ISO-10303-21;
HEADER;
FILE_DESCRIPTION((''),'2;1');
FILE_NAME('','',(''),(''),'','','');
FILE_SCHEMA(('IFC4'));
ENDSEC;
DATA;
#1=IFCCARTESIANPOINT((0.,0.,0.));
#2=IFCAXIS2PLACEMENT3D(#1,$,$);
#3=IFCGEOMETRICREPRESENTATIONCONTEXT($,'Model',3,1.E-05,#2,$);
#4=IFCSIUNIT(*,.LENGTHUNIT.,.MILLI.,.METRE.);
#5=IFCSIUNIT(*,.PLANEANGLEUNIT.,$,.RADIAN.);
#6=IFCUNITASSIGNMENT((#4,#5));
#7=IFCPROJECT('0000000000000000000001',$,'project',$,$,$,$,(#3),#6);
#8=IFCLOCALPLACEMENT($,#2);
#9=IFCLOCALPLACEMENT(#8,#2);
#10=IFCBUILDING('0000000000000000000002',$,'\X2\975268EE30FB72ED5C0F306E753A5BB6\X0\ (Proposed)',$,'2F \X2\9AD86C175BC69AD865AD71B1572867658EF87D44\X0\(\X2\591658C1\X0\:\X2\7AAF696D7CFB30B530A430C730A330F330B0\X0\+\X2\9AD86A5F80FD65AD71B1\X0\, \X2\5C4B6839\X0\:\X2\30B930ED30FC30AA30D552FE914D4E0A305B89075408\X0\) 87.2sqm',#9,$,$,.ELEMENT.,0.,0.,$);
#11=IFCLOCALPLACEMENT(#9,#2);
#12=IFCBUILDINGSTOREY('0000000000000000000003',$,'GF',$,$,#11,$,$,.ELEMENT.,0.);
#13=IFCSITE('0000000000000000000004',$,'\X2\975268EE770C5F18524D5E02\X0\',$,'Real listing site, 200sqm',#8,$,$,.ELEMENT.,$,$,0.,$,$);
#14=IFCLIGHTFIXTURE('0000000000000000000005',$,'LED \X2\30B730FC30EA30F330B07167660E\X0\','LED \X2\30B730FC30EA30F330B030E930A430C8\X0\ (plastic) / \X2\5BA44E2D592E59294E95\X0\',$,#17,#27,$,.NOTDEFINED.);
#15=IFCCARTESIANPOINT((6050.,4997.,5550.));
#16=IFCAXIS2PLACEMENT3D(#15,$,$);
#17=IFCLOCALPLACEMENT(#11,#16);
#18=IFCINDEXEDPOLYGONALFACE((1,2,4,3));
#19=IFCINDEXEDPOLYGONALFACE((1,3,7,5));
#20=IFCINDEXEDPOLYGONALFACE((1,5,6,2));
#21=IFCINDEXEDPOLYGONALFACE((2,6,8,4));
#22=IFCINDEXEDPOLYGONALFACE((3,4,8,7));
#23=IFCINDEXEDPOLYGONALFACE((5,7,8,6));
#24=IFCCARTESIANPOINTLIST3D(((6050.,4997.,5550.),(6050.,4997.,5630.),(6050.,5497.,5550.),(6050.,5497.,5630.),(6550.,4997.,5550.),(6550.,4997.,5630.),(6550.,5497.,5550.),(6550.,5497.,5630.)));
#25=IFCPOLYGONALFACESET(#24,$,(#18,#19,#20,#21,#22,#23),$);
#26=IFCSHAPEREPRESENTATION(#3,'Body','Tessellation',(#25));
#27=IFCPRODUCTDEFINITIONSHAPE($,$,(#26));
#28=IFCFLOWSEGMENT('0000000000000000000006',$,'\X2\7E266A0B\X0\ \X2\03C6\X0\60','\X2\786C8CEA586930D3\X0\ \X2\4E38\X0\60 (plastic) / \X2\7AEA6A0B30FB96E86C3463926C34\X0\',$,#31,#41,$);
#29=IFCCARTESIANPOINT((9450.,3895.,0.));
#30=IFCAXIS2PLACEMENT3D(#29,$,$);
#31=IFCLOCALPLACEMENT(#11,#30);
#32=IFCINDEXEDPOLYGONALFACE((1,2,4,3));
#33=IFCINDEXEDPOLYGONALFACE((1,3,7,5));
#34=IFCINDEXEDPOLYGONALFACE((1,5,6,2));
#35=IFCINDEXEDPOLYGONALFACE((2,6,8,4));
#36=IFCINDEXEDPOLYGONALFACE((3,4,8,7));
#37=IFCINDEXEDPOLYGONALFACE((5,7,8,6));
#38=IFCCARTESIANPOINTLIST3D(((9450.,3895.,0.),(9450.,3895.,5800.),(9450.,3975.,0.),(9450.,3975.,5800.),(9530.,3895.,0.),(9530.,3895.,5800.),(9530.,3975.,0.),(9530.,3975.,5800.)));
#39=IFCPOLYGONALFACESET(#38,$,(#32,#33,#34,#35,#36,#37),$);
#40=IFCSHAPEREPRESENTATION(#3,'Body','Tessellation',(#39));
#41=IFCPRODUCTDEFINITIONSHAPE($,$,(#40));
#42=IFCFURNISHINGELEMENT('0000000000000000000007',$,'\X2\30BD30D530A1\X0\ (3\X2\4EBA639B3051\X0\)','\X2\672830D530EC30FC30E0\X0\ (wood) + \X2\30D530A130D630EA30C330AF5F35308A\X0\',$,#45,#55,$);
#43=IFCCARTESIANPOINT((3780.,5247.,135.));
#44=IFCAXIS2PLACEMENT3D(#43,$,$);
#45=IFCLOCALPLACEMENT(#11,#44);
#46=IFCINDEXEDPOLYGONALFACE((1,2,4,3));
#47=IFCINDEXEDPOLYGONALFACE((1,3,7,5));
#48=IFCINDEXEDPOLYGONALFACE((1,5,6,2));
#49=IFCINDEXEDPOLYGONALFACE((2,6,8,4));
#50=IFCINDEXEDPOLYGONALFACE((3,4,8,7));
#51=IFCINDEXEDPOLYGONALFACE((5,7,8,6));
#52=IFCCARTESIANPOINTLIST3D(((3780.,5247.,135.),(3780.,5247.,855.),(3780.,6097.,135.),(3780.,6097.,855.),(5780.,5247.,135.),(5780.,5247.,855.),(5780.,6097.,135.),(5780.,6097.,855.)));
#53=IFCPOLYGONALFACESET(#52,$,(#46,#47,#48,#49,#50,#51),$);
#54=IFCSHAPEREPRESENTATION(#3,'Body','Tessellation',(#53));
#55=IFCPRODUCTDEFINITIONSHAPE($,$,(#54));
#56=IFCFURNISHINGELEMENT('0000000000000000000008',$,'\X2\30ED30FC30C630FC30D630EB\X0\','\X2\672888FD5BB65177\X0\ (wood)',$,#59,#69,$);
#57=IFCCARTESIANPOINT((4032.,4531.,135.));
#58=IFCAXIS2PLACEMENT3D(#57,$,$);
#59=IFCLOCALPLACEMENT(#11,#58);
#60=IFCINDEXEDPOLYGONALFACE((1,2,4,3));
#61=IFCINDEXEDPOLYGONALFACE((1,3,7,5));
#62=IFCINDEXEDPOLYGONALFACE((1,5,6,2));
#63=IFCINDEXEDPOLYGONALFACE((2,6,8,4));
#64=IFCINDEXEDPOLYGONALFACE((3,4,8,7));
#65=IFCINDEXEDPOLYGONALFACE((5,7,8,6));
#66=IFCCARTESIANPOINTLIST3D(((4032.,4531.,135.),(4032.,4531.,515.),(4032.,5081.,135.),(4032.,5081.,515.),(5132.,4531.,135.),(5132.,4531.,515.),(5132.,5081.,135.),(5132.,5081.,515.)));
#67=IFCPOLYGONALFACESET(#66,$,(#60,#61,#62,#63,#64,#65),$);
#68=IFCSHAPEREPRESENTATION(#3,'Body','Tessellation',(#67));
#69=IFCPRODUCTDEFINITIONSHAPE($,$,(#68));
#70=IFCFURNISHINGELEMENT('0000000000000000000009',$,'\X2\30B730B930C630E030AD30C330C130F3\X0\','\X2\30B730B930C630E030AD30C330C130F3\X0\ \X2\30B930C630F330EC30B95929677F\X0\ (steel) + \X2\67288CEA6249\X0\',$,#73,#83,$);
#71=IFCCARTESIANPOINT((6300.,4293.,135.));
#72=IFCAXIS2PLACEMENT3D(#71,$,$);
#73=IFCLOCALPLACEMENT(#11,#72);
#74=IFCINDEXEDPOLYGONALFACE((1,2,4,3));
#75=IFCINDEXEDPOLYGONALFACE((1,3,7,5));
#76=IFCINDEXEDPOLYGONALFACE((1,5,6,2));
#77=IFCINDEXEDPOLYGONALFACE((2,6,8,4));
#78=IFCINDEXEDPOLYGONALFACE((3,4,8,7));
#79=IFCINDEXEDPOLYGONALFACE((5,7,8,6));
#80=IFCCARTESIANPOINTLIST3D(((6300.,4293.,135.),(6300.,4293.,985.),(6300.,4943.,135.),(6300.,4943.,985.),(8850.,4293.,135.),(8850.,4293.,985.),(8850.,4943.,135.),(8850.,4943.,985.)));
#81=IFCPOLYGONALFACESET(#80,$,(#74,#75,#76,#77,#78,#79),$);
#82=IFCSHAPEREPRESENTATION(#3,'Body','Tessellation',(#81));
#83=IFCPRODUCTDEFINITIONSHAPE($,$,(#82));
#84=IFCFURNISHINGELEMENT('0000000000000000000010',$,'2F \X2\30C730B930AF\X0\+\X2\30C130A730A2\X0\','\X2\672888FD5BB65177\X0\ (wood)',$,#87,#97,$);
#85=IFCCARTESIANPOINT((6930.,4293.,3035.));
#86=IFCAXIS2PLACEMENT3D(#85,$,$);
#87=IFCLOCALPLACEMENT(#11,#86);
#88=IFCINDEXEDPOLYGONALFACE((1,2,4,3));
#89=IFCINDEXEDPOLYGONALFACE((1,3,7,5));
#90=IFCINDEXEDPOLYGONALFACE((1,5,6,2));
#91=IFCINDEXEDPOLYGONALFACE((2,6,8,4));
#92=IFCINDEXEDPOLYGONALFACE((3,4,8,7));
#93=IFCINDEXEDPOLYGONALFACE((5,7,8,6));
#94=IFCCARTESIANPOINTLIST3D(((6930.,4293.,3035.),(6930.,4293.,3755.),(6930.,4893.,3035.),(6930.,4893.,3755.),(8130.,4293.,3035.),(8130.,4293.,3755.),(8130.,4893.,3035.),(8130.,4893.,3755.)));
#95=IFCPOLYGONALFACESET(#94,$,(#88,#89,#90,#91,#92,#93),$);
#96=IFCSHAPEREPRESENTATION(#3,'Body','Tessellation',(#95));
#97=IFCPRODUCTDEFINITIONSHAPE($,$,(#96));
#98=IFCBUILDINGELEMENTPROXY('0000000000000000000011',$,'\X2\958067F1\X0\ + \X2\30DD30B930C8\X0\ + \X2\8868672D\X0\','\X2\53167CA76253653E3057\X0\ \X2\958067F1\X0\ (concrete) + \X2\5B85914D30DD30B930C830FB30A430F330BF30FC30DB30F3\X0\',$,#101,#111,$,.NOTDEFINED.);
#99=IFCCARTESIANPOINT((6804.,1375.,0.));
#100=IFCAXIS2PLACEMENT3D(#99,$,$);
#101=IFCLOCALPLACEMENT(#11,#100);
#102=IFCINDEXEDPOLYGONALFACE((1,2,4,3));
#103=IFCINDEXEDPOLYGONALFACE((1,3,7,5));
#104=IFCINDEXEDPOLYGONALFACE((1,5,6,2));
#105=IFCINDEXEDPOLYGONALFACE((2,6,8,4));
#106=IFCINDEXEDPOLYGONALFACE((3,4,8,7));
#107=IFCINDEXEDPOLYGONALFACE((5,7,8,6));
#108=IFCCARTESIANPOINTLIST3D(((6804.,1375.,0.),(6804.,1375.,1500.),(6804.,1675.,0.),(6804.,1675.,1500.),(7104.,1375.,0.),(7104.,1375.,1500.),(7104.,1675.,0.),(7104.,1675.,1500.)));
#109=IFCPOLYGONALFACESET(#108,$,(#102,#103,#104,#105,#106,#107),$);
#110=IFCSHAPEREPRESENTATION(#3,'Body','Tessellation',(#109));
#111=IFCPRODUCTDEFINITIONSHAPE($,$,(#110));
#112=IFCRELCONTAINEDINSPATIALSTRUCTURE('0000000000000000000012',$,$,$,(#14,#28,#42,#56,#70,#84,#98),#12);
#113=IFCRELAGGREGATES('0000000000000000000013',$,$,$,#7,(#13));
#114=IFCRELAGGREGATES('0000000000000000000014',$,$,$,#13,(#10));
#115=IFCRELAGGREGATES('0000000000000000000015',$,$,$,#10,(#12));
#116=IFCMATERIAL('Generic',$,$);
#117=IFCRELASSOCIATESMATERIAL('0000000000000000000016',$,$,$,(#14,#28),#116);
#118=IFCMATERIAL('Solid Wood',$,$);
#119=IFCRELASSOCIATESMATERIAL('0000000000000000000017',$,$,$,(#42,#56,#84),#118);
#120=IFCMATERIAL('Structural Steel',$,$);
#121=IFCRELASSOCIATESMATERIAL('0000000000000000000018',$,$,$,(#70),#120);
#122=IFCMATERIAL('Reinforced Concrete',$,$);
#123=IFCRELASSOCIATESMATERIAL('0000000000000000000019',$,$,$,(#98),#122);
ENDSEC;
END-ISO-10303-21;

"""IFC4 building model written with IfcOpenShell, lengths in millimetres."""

from ifc_helpers import new_model, si_unit, frame, frame_2d, origin, place, context, project, spatial, rectangle, extrude, material, element, save


model = new_model("IFC4")

# Units and contexts
model_context = context("Model", 3, precision=1e-05, world=origin())
ifc_project = project(units=[si_unit("LENGTHUNIT", "METRE", prefix="MILLI"), si_unit("PLANEANGLEUNIT", "RADIAN")], contexts=[model_context])

# Site, building, storey
site_placement = place(None, origin())
site = spatial("IfcSite", under=ifc_project, at=site_placement, Name="青森県弘前市", ObjectType="Real listing site, 200sqm", CompositionType="ELEMENT", RefElevation=0.0)
building_placement = place(site_placement, origin())
building = spatial("IfcBuilding", under=site, at=building_placement, Name="青森・狭小の町家 (Proposed)", ObjectType="2F 高気密高断熱在来軸組(外壁:窯業系サイディング+高機能断熱, 屋根:スローオフ勾配上せ複合) 87.2sqm", CompositionType="ELEMENT", ElevationOfRefHeight=0.0, ElevationOfTerrain=0.0)
storey_placement = place(building_placement, origin())
storey = spatial("IfcBuildingStorey", under=building, at=storey_placement, Name="GF", CompositionType="ELEMENT", Elevation=0.0)

# Shared definitions
ifc_material_1 = material(Name="Solid Wood")

# Shared definitions
ifc_material_2 = material(Name="Reinforced Concrete")

# Shared definitions
ifc_material_3 = material(Name="Structural Steel")

# Shared definitions
ifc_material_4 = material(Name="Generic")

# Light fixture
light_fixture_1_placement = place(storey_placement, frame((6050.0, 4997.0, 5550.0)))
element("IfcLightFixture", 1, at=light_fixture_1_placement, inside=storey, material=ifc_material_4, Name="LED シーリング照明", Description="LED シーリングライト (plastic) / 室中央天井", PredefinedType="NOTDEFINED", context=model_context, shape_type="SweptSolid", body=[
    extrude(rectangle(XDim=500.0, YDim=500.0, at=frame_2d((250.0, 250.0))), frame((6050.0, 4997.0, 5550.0)), (0.0, 0.0, 1.0), 80.0),
])

# Flow segment
flow_segment_placement = place(storey_placement, frame((9450.0, 3895.0, 0.0)))
element("IfcFlowSegment", 2, at=flow_segment_placement, inside=storey, material=ifc_material_4, Name="縦樋 φ60", Description="硬質塩ビ 丸60 (plastic) / 竪樋・雨水排水", context=model_context, shape_type="SweptSolid", body=[
    extrude(rectangle(XDim=80.0, YDim=80.0, at=frame_2d((40.0, 40.0))), frame((9450.0, 3895.0, 0.0)), (0.0, 0.0, 1.0), 5800.0),
])

# Furnishing elements
furnishing_1_placement = place(storey_placement, frame((3780.0, 5247.0, 135.0)))
element("IfcFurnishingElement", 3, at=furnishing_1_placement, inside=storey, material=ifc_material_1, Name="ソファ (3人掛け)", Description="木フレーム (wood) + ファブリック張り", context=model_context, shape_type="SweptSolid", body=[
    extrude(rectangle(XDim=2000.0, YDim=850.0, at=frame_2d((1000.0, 425.0))), frame((3780.0, 5247.0, 135.0)), (0.0, 0.0, 1.0), 720.0),
])
furnishing_2_placement = place(storey_placement, frame((4032.0, 4531.0, 135.0)))
element("IfcFurnishingElement", 4, at=furnishing_2_placement, inside=storey, material=ifc_material_1, Name="ローテーブル", Description="木製家具 (wood)", context=model_context, shape_type="SweptSolid", body=[
    extrude(rectangle(XDim=1100.0, YDim=550.0, at=frame_2d((550.0, 275.0))), frame((4032.0, 4531.0, 135.0)), (0.0, 0.0, 1.0), 380.0),
])
furnishing_3_placement = place(storey_placement, frame((6300.0, 4293.0, 135.0)))
element("IfcFurnishingElement", 5, at=furnishing_3_placement, inside=storey, material=ifc_material_3, Name="システムキッチン", Description="システムキッチン ステンレス天板 (steel) + 木質扉", context=model_context, shape_type="SweptSolid", body=[
    extrude(rectangle(XDim=2550.0, YDim=650.0, at=frame_2d((1275.0, 325.0))), frame((6300.0, 4293.0, 135.0)), (0.0, 0.0, 1.0), 850.0),
])
furnishing_4_placement = place(storey_placement, frame((6930.0, 4293.0, 3035.0)))
element("IfcFurnishingElement", 6, at=furnishing_4_placement, inside=storey, material=ifc_material_1, Name="2F デスク+チェア", Description="木製家具 (wood)", context=model_context, shape_type="SweptSolid", body=[
    extrude(rectangle(XDim=1200.0, YDim=600.0, at=frame_2d((600.0, 300.0))), frame((6930.0, 4293.0, 3035.0)), (0.0, 0.0, 1.0), 720.0),
])

# Building element proxy
proxy_placement = place(storey_placement, frame((6804.0, 1375.0, 0.0)))
element("IfcBuildingElementProxy", 7, at=proxy_placement, inside=storey, material=ifc_material_2, Name="門柱 + ポスト + 表札", Description="化粧打放し 門柱 (concrete) + 宅配ポスト・インターホン", PredefinedType="NOTDEFINED", context=model_context, shape_type="SweptSolid", body=[
    extrude(rectangle(XDim=300.0, YDim=300.0, at=frame_2d((150.0, 150.0))), frame((6804.0, 1375.0, 0.0)), (0.0, 0.0, 1.0), 1500.0),
])

save(model, "model.ifc")
